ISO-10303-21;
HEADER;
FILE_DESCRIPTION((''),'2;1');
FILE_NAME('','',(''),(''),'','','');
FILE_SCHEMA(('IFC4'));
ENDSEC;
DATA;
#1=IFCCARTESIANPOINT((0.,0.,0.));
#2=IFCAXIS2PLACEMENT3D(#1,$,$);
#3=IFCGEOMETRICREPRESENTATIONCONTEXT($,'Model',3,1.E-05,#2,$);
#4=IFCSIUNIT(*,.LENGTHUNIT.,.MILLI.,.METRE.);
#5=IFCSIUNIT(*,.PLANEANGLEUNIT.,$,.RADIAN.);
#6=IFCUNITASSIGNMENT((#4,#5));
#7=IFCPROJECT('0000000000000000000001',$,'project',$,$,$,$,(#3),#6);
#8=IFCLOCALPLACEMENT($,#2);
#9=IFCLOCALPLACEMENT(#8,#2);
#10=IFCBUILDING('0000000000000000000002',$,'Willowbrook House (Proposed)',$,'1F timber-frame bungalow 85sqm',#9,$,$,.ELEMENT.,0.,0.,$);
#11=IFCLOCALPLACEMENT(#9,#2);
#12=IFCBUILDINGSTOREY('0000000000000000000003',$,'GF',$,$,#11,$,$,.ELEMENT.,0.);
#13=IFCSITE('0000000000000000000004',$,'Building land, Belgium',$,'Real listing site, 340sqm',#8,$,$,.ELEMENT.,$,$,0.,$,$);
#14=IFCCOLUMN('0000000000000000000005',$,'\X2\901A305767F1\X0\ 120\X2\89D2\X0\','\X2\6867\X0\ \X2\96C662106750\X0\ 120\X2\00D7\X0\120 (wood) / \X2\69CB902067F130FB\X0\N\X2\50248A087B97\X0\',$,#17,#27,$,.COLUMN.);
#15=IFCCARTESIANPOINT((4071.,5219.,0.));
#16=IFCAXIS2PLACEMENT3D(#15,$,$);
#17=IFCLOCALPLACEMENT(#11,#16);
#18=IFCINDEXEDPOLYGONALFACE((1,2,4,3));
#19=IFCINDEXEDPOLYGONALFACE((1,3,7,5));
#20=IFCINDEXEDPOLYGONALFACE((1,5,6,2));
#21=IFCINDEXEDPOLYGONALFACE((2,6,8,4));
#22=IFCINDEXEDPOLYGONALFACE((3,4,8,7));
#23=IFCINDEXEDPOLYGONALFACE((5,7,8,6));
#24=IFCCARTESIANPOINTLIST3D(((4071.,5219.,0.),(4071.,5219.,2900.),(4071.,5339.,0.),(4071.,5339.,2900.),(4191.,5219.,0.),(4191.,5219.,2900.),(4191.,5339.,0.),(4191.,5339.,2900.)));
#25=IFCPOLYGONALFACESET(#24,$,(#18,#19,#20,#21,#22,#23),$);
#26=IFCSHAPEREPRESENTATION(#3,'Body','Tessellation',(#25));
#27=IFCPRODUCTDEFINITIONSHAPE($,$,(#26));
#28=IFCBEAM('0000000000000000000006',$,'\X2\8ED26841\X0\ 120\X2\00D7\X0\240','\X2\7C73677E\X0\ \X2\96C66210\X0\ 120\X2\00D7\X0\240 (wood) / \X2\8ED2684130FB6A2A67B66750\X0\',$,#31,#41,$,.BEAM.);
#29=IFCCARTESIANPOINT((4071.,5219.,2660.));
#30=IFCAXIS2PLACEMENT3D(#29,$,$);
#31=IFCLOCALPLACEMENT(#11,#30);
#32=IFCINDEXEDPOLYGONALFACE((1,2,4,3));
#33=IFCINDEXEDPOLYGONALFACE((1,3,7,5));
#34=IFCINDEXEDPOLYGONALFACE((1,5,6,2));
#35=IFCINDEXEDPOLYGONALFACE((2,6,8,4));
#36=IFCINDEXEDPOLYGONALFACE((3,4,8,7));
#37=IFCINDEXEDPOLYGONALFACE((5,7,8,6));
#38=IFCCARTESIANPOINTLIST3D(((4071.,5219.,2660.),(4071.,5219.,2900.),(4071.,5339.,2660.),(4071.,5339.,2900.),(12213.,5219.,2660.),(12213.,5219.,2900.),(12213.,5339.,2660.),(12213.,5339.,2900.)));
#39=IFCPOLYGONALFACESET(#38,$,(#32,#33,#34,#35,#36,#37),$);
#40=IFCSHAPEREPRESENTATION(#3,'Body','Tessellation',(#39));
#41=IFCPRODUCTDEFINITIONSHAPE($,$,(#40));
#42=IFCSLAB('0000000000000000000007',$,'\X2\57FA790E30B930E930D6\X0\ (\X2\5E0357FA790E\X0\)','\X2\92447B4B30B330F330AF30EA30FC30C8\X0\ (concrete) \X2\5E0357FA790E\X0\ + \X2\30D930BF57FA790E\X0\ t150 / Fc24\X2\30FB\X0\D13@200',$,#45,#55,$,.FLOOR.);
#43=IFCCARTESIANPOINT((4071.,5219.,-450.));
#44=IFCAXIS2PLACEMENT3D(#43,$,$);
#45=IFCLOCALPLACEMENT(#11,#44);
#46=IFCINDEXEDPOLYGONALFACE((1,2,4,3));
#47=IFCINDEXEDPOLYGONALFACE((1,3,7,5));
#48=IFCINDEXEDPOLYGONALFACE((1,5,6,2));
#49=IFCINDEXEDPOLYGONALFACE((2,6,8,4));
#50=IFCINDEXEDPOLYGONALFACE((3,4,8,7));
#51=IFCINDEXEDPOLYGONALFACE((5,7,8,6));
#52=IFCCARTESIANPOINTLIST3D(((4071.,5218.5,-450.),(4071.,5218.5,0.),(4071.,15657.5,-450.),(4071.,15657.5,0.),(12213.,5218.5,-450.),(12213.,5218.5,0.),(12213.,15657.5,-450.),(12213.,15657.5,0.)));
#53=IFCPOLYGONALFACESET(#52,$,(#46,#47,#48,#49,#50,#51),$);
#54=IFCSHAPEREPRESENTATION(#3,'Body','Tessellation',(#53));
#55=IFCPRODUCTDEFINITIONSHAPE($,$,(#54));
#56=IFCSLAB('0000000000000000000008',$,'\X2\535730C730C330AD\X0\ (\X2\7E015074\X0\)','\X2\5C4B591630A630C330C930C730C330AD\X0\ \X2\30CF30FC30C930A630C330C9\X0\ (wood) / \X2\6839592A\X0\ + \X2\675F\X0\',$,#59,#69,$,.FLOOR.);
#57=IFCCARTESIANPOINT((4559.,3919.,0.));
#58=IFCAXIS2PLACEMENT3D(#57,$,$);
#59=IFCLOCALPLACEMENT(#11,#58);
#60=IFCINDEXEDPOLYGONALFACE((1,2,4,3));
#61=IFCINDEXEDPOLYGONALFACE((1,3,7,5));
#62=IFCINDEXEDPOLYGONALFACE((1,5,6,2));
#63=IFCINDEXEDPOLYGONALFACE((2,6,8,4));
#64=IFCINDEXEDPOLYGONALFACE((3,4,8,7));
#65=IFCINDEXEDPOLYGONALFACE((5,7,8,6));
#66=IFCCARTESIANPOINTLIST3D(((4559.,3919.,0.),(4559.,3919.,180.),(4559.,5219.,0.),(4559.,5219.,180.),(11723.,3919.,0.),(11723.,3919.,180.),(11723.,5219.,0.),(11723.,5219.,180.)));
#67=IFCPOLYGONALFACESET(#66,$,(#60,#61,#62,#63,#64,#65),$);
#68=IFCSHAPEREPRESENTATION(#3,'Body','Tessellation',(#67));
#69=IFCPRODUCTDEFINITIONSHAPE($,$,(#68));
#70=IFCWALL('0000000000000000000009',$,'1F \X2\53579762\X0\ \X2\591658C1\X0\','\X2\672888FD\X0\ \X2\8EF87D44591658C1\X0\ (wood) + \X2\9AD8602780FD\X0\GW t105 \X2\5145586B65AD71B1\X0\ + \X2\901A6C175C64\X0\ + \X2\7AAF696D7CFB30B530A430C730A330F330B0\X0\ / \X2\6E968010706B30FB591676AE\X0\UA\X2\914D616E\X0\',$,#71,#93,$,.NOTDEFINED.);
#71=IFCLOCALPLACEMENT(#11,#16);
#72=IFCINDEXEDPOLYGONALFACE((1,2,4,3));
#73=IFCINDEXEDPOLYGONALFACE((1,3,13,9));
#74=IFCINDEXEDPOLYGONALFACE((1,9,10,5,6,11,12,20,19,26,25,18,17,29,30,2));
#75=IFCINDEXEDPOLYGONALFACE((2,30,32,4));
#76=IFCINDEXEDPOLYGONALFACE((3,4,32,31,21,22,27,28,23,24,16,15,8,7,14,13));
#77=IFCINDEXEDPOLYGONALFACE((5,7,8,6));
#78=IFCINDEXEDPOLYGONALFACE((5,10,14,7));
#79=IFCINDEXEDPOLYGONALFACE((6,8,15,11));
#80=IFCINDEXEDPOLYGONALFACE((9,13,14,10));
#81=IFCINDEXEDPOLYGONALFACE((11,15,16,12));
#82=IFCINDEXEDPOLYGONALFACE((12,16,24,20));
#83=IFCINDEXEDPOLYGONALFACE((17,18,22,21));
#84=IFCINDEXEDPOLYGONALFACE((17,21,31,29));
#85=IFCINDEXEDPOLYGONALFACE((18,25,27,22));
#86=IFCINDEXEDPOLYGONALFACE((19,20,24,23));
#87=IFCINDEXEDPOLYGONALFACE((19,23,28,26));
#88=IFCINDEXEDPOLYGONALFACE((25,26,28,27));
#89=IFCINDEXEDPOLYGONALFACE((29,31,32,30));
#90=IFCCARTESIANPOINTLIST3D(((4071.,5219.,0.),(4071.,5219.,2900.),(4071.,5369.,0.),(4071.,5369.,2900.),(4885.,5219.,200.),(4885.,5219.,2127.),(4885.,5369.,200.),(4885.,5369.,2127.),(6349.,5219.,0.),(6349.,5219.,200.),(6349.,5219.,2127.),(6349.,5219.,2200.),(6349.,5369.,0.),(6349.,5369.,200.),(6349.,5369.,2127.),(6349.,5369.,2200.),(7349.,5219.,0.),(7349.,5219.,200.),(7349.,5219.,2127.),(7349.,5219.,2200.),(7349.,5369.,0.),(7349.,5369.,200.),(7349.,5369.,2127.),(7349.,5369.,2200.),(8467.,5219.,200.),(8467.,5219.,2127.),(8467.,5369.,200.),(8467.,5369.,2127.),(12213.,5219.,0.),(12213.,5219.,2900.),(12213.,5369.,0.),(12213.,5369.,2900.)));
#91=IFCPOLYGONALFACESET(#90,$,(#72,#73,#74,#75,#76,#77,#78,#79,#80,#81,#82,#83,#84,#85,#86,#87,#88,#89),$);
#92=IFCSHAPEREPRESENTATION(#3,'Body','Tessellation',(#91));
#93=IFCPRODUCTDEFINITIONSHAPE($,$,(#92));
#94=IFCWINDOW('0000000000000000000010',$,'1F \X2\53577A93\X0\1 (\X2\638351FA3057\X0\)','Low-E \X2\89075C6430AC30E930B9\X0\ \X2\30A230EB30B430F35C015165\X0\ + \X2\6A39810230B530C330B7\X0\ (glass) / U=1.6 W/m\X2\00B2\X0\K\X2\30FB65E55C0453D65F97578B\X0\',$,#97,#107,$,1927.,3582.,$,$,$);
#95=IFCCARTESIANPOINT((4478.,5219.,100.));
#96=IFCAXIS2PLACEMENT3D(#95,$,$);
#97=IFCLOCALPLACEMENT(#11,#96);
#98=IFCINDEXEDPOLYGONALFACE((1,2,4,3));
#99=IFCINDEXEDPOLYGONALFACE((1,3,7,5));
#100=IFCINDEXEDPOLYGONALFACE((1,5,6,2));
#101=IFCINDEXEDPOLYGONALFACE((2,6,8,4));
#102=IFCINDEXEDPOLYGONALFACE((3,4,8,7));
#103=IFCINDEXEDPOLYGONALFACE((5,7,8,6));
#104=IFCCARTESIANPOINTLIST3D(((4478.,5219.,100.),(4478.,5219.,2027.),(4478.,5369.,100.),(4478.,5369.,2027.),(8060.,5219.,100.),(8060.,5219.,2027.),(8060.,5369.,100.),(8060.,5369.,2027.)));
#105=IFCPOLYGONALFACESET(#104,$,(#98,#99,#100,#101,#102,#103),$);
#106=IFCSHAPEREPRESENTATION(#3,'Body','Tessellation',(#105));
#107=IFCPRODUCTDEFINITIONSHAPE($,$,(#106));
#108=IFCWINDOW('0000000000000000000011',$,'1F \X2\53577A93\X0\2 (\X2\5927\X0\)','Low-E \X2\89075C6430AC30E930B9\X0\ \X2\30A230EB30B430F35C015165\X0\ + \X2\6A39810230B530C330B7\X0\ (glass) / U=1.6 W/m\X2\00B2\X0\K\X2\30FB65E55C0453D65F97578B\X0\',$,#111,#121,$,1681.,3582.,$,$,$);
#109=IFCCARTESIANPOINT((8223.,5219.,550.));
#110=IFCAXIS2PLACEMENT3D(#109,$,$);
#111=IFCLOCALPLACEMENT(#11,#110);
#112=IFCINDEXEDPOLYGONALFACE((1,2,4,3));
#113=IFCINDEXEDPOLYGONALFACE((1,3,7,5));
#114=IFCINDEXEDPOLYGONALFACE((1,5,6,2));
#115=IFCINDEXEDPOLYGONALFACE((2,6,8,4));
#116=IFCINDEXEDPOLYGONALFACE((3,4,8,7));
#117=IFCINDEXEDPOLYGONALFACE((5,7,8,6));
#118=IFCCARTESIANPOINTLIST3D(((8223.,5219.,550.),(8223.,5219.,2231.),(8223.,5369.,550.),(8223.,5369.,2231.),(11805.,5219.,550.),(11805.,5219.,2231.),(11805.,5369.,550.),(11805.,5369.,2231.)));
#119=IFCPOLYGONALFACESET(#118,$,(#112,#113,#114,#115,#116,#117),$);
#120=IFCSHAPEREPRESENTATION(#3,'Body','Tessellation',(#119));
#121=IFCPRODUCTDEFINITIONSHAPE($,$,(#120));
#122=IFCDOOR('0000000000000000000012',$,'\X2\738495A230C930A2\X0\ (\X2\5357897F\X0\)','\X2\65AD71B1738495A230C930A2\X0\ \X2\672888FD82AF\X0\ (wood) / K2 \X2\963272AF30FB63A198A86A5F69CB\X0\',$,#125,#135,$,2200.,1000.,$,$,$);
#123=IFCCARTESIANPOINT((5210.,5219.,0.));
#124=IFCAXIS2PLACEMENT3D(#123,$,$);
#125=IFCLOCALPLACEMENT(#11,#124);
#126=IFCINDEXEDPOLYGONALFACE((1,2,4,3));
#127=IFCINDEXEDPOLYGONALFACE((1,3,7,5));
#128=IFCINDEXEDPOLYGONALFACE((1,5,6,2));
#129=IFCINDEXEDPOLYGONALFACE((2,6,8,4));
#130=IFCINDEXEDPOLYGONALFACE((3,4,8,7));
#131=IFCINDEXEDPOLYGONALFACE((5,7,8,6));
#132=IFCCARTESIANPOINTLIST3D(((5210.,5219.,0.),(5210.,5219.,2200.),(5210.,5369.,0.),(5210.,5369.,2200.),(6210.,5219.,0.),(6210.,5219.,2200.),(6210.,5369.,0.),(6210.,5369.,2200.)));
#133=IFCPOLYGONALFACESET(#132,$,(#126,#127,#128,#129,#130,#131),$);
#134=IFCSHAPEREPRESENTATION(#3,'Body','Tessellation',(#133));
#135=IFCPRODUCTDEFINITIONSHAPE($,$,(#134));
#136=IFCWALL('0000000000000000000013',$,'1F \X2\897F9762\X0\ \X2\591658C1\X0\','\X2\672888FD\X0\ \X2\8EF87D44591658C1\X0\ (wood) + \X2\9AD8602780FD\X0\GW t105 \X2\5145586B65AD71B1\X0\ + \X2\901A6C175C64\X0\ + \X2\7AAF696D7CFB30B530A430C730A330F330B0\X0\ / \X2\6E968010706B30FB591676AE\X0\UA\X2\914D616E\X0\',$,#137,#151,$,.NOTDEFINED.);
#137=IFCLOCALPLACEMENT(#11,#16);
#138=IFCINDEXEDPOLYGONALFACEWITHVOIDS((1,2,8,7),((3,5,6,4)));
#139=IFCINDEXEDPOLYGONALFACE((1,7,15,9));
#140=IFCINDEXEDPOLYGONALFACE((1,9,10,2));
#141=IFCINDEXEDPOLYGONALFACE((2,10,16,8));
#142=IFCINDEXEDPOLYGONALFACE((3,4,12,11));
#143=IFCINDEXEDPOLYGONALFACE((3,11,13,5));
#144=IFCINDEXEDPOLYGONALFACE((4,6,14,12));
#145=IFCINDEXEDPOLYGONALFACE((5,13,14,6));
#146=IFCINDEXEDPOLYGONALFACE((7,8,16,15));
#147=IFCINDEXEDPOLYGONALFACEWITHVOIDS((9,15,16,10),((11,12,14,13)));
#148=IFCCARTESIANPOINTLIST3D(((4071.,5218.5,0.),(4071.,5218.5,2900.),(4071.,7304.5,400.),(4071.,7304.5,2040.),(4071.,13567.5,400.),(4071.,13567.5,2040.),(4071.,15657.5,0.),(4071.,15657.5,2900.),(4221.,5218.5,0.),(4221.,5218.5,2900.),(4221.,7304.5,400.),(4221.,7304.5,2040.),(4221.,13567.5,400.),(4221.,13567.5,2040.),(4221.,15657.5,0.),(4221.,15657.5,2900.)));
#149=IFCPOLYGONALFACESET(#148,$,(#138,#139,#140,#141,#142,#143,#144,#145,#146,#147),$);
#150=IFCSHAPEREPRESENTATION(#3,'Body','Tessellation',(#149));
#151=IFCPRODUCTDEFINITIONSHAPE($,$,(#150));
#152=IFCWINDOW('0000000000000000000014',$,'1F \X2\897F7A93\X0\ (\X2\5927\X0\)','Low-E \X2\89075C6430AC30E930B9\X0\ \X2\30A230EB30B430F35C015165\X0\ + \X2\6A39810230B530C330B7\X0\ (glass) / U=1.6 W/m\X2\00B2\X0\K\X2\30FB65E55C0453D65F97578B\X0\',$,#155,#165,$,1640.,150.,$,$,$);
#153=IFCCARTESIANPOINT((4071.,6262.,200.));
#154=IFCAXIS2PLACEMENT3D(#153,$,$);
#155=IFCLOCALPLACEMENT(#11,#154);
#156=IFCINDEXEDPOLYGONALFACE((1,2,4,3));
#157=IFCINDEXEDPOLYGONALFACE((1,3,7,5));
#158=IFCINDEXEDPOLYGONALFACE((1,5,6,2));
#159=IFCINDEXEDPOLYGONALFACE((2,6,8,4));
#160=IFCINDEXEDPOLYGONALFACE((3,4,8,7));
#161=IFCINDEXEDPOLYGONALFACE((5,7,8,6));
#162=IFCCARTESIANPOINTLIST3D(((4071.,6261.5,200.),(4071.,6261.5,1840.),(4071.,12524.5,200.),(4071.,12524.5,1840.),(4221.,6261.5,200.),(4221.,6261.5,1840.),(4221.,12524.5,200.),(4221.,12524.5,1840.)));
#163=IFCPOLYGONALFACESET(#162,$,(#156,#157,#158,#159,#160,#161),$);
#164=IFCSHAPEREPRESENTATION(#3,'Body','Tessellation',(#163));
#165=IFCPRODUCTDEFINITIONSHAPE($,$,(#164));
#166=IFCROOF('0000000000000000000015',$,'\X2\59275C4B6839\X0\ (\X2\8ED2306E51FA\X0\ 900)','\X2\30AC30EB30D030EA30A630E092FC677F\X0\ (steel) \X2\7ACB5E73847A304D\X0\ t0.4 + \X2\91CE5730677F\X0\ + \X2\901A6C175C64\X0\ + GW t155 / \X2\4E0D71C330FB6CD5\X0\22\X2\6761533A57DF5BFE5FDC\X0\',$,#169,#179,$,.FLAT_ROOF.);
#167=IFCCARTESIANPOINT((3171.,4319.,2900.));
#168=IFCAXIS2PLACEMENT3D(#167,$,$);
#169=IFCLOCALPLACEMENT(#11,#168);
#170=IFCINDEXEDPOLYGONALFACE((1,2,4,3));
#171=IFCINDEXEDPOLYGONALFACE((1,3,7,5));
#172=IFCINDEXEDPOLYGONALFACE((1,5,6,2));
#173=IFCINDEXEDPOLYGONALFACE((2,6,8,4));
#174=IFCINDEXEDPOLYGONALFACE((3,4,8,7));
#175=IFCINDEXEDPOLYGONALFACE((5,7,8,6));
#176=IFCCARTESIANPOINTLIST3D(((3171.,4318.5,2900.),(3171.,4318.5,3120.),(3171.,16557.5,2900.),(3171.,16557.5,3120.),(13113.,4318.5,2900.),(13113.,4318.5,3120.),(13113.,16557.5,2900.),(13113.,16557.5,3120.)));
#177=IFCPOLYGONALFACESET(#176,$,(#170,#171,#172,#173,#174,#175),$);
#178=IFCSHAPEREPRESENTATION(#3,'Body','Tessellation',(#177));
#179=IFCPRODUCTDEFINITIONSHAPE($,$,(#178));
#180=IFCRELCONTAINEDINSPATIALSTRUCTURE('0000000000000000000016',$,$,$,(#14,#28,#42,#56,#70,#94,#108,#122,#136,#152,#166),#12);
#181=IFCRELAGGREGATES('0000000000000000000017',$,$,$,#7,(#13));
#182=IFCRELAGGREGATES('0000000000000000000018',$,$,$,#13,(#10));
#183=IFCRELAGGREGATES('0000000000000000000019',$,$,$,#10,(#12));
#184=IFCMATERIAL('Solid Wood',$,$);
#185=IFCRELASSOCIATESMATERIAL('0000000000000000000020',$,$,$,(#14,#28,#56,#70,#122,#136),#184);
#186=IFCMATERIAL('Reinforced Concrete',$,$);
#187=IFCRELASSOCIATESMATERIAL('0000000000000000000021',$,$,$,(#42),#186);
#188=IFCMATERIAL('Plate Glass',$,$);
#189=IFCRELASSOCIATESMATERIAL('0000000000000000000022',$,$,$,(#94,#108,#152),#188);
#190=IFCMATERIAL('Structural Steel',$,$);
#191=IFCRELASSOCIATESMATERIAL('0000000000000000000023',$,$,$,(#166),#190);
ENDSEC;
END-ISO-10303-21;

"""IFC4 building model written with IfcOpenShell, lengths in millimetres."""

from ifc_helpers import new_model, si_unit, frame, frame_2d, origin, place, context, project, spatial, rectangle, extrude, material, element, fill, save


model = new_model("IFC4")

# Units and contexts
model_context = context("Model", 3, precision=1e-05, world=origin())
ifc_project = project(units=[si_unit("LENGTHUNIT", "METRE", prefix="MILLI"), si_unit("PLANEANGLEUNIT", "RADIAN")], contexts=[model_context])

# Site, building, storey
site_placement = place(None, origin())
site = spatial("IfcSite", under=ifc_project, at=site_placement, Name="Building land, Belgium", ObjectType="Real listing site, 340sqm", CompositionType="ELEMENT", RefElevation=0.0)
building_placement = place(site_placement, origin())
building = spatial("IfcBuilding", under=site, at=building_placement, Name="Willowbrook House (Proposed)", ObjectType="1F timber-frame bungalow 85sqm", CompositionType="ELEMENT", ElevationOfRefHeight=0.0, ElevationOfTerrain=0.0)
storey_placement = place(building_placement, origin())
storey = spatial("IfcBuildingStorey", under=building, at=storey_placement, Name="GF", CompositionType="ELEMENT", Elevation=0.0)

# Column
ifc_material_1 = material(Name="Solid Wood")
column_1_placement = place(storey_placement, frame((4071.0, 5219.0, 0.0)))
element("IfcColumn", 1, at=column_1_placement, inside=storey, material=ifc_material_1, Name="通し柱 120角", Description="桧 集成材 120×120 (wood) / 構造柱・N値計算", PredefinedType="COLUMN", context=model_context, shape_type="SweptSolid", body=[
    extrude(rectangle(XDim=120.0, YDim=120.0, at=frame_2d((60.0, 60.0))), frame((4071.0, 5219.0, 0.0)), (0.0, 0.0, 1.0), 2900.0),
])

# Beam
beam_1_placement = place(storey_placement, frame((4071.0, 5219.0, 2660.0)))
element("IfcBeam", 2, at=beam_1_placement, inside=storey, material=ifc_material_1, Name="軒桁 120×240", Description="米松 集成 120×240 (wood) / 軒桁・横架材", PredefinedType="BEAM", context=model_context, shape_type="SweptSolid", body=[
    extrude(rectangle(XDim=8142.0, YDim=120.0, at=frame_2d((4071.0, 60.0))), frame((4071.0, 5219.0, 2660.0)), (0.0, 0.0, 1.0), 240.0),
])

# Slabs
ifc_material_2 = material(Name="Reinforced Concrete")
slab_1_placement = place(storey_placement, frame((4071.0, 5219.0, -450.0)))
element("IfcSlab", 3, at=slab_1_placement, inside=storey, material=ifc_material_2, Name="基礎スラブ (布基礎)", Description="鉄筋コンクリート (concrete) 布基礎 + ベタ基礎 t150 / Fc24・D13@200", PredefinedType="FLOOR", context=model_context, shape_type="SweptSolid", body=[
    extrude(rectangle(XDim=8142.0, YDim=10439.0, at=frame_2d((4071.0, 5219.0))), frame((4071.0, 5219.0, -450.0)), (0.0, 0.0, 1.0), 450.0),
])
slab_2_placement = place(storey_placement, frame((4559.0, 3919.0, 0.0)))
element("IfcSlab", 4, at=slab_2_placement, inside=storey, material=ifc_material_1, Name="南デッキ (縁側)", Description="屋外ウッドデッキ ハードウッド (wood) / 根太 + 束", PredefinedType="FLOOR", context=model_context, shape_type="SweptSolid", body=[
    extrude(rectangle(XDim=7164.0, YDim=1300.0, at=frame_2d((3582.0, 650.0))), frame((4559.0, 3919.0, 0.0)), (0.0, 0.0, 1.0), 180.0),
])

# Wall, openings, windows, door
wall_1_placement = place(storey_placement, frame((4071.0, 5219.0, 0.0)))
wall_1 = element("IfcWall", 5, at=wall_1_placement, inside=storey, material=ifc_material_1, Name="1F 南面 外壁", Description="木製 軸組外壁 (wood) + 高性能GW t105 充填断熱 + 通気層 + 窯業系サイディング / 準耐火・外皮UA配慮", PredefinedType="NOTDEFINED", context=model_context, shape_type="SweptSolid", body=[
    extrude(rectangle(XDim=8142.0, YDim=150.0, at=frame_2d((4071.0, 75.0))), frame((4071.0, 5219.0, 0.0)), (0.0, 0.0, 1.0), 2900.0),
])
opening_1_placement = place(storey_placement, frame((4478.0, 5219.0, 100.0)))
opening_1 = element("IfcOpeningElement", 6, at=opening_1_placement, cuts=wall_1, PredefinedType="NOTDEFINED", context=model_context, shape_type="SweptSolid", body=[
    extrude(rectangle(XDim=3582.0, YDim=150.0, at=frame_2d((1791.0, 75.0))), frame((4478.0, 5219.0, 100.0)), (0.0, 0.0, 1.0), 1927.0),
])
opening_2_placement = place(storey_placement, frame((8223.0, 5219.0, 550.0)))
opening_2 = element("IfcOpeningElement", 7, at=opening_2_placement, cuts=wall_1, PredefinedType="NOTDEFINED", context=model_context, shape_type="SweptSolid", body=[
    extrude(rectangle(XDim=3582.0, YDim=150.0, at=frame_2d((1791.0, 75.0))), frame((8223.0, 5219.0, 550.0)), (0.0, 0.0, 1.0), 1681.0),
])
opening_3_placement = place(storey_placement, frame((5210.0, 5219.0, 0.0)))
opening_3 = element("IfcOpeningElement", 8, at=opening_3_placement, cuts=wall_1, PredefinedType="NOTDEFINED", context=model_context, shape_type="SweptSolid", body=[
    extrude(rectangle(XDim=1000.0, YDim=150.0, at=frame_2d((500.0, 75.0))), frame((5210.0, 5219.0, 0.0)), (0.0, 0.0, 1.0), 2200.0),
])
ifc_material_3 = material(Name="Plate Glass")
window_1_placement = place(storey_placement, frame((4478.0, 5219.0, 100.0)))
window_1 = element("IfcWindow", 9, at=window_1_placement, inside=storey, material=ifc_material_3, Name="1F 南窓1 (掃出し)", Description="Low-E 複層ガラス アルゴン封入 + 樹脂サッシ (glass) / U=1.6 W/m²K・日射取得型", OverallHeight=1927.0, OverallWidth=3582.0, context=model_context, shape_type="SweptSolid", body=[
    extrude(rectangle(XDim=3582.0, YDim=150.0, at=frame_2d((1791.0, 75.0))), frame((4478.0, 5219.0, 100.0)), (0.0, 0.0, 1.0), 1927.0),
])
fill(opening_1, window_1)
window_2_placement = place(storey_placement, frame((8223.0, 5219.0, 550.0)))
window_2 = element("IfcWindow", 10, at=window_2_placement, inside=storey, material=ifc_material_3, Name="1F 南窓2 (大)", Description="Low-E 複層ガラス アルゴン封入 + 樹脂サッシ (glass) / U=1.6 W/m²K・日射取得型", OverallHeight=1681.0, OverallWidth=3582.0, context=model_context, shape_type="SweptSolid", body=[
    extrude(rectangle(XDim=3582.0, YDim=150.0, at=frame_2d((1791.0, 75.0))), frame((8223.0, 5219.0, 550.0)), (0.0, 0.0, 1.0), 1681.0),
])
fill(opening_2, window_2)
door_placement = place(storey_placement, frame((5210.0, 5219.0, 0.0)))
door = element("IfcDoor", 11, at=door_placement, inside=storey, material=ifc_material_1, Name="玄関ドア (南西)", Description="断熱玄関ドア 木製芯 (wood) / K2 防犯・採風機構", OverallHeight=2200.0, OverallWidth=1000.0, context=model_context, shape_type="SweptSolid", body=[
    extrude(rectangle(XDim=1000.0, YDim=150.0, at=frame_2d((500.0, 75.0))), frame((5210.0, 5219.0, 0.0)), (0.0, 0.0, 1.0), 2200.0),
])
fill(opening_3, door)

# Wall, opening, window
wall_2_placement = place(storey_placement, frame((4071.0, 5219.0, 0.0)))
wall_2 = element("IfcWall", 12, at=wall_2_placement, inside=storey, material=ifc_material_1, Name="1F 西面 外壁", Description="木製 軸組外壁 (wood) + 高性能GW t105 充填断熱 + 通気層 + 窯業系サイディング / 準耐火・外皮UA配慮", PredefinedType="NOTDEFINED", context=model_context, shape_type="SweptSolid", body=[
    extrude(rectangle(XDim=150.0, YDim=10439.0, at=frame_2d((75.0, 5219.0))), frame((4071.0, 5219.0, 0.0)), (0.0, 0.0, 1.0), 2900.0),
])
opening_4_placement = place(storey_placement, frame((4071.0, 6262.0, 200.0)))
opening_4 = element("IfcOpeningElement", 13, at=opening_4_placement, cuts=wall_2, PredefinedType="NOTDEFINED", context=model_context, shape_type="SweptSolid", body=[
    extrude(rectangle(XDim=150.0, YDim=6263.0, at=frame_2d((75.0, 3131.0))), frame((4071.0, 6262.0, 200.0)), (0.0, 0.0, 1.0), 1640.0),
])
window_3_placement = place(storey_placement, frame((4071.0, 6262.0, 200.0)))
window_3 = element("IfcWindow", 14, at=window_3_placement, inside=storey, material=ifc_material_3, Name="1F 西窓 (大)", Description="Low-E 複層ガラス アルゴン封入 + 樹脂サッシ (glass) / U=1.6 W/m²K・日射取得型", OverallHeight=1640.0, OverallWidth=150.0, context=model_context, shape_type="SweptSolid", body=[
    extrude(rectangle(XDim=150.0, YDim=6263.0, at=frame_2d((75.0, 3131.0))), frame((4071.0, 6262.0, 200.0)), (0.0, 0.0, 1.0), 1640.0),
])
fill(opening_4, window_3)

# Roof
ifc_material_4 = material(Name="Structural Steel")
roof_placement = place(storey_placement, frame((3171.0, 4319.0, 2900.0)))
element("IfcRoof", 15, at=roof_placement, inside=storey, material=ifc_material_4, Name="大屋根 (軒の出 900)", Description="ガルバリウム鋼板 (steel) 立平葺き t0.4 + 野地板 + 通気層 + GW t155 / 不燃・法22条区域対応", PredefinedType="FLAT_ROOF", context=model_context, shape_type="SweptSolid", body=[
    extrude(rectangle(XDim=9942.0, YDim=12239.0, at=frame_2d((4971.0, 6119.0))), frame((3171.0, 4319.0, 2900.0)), (0.0, 0.0, 1.0), 220.0),
])

save(model, "model.ifc")
